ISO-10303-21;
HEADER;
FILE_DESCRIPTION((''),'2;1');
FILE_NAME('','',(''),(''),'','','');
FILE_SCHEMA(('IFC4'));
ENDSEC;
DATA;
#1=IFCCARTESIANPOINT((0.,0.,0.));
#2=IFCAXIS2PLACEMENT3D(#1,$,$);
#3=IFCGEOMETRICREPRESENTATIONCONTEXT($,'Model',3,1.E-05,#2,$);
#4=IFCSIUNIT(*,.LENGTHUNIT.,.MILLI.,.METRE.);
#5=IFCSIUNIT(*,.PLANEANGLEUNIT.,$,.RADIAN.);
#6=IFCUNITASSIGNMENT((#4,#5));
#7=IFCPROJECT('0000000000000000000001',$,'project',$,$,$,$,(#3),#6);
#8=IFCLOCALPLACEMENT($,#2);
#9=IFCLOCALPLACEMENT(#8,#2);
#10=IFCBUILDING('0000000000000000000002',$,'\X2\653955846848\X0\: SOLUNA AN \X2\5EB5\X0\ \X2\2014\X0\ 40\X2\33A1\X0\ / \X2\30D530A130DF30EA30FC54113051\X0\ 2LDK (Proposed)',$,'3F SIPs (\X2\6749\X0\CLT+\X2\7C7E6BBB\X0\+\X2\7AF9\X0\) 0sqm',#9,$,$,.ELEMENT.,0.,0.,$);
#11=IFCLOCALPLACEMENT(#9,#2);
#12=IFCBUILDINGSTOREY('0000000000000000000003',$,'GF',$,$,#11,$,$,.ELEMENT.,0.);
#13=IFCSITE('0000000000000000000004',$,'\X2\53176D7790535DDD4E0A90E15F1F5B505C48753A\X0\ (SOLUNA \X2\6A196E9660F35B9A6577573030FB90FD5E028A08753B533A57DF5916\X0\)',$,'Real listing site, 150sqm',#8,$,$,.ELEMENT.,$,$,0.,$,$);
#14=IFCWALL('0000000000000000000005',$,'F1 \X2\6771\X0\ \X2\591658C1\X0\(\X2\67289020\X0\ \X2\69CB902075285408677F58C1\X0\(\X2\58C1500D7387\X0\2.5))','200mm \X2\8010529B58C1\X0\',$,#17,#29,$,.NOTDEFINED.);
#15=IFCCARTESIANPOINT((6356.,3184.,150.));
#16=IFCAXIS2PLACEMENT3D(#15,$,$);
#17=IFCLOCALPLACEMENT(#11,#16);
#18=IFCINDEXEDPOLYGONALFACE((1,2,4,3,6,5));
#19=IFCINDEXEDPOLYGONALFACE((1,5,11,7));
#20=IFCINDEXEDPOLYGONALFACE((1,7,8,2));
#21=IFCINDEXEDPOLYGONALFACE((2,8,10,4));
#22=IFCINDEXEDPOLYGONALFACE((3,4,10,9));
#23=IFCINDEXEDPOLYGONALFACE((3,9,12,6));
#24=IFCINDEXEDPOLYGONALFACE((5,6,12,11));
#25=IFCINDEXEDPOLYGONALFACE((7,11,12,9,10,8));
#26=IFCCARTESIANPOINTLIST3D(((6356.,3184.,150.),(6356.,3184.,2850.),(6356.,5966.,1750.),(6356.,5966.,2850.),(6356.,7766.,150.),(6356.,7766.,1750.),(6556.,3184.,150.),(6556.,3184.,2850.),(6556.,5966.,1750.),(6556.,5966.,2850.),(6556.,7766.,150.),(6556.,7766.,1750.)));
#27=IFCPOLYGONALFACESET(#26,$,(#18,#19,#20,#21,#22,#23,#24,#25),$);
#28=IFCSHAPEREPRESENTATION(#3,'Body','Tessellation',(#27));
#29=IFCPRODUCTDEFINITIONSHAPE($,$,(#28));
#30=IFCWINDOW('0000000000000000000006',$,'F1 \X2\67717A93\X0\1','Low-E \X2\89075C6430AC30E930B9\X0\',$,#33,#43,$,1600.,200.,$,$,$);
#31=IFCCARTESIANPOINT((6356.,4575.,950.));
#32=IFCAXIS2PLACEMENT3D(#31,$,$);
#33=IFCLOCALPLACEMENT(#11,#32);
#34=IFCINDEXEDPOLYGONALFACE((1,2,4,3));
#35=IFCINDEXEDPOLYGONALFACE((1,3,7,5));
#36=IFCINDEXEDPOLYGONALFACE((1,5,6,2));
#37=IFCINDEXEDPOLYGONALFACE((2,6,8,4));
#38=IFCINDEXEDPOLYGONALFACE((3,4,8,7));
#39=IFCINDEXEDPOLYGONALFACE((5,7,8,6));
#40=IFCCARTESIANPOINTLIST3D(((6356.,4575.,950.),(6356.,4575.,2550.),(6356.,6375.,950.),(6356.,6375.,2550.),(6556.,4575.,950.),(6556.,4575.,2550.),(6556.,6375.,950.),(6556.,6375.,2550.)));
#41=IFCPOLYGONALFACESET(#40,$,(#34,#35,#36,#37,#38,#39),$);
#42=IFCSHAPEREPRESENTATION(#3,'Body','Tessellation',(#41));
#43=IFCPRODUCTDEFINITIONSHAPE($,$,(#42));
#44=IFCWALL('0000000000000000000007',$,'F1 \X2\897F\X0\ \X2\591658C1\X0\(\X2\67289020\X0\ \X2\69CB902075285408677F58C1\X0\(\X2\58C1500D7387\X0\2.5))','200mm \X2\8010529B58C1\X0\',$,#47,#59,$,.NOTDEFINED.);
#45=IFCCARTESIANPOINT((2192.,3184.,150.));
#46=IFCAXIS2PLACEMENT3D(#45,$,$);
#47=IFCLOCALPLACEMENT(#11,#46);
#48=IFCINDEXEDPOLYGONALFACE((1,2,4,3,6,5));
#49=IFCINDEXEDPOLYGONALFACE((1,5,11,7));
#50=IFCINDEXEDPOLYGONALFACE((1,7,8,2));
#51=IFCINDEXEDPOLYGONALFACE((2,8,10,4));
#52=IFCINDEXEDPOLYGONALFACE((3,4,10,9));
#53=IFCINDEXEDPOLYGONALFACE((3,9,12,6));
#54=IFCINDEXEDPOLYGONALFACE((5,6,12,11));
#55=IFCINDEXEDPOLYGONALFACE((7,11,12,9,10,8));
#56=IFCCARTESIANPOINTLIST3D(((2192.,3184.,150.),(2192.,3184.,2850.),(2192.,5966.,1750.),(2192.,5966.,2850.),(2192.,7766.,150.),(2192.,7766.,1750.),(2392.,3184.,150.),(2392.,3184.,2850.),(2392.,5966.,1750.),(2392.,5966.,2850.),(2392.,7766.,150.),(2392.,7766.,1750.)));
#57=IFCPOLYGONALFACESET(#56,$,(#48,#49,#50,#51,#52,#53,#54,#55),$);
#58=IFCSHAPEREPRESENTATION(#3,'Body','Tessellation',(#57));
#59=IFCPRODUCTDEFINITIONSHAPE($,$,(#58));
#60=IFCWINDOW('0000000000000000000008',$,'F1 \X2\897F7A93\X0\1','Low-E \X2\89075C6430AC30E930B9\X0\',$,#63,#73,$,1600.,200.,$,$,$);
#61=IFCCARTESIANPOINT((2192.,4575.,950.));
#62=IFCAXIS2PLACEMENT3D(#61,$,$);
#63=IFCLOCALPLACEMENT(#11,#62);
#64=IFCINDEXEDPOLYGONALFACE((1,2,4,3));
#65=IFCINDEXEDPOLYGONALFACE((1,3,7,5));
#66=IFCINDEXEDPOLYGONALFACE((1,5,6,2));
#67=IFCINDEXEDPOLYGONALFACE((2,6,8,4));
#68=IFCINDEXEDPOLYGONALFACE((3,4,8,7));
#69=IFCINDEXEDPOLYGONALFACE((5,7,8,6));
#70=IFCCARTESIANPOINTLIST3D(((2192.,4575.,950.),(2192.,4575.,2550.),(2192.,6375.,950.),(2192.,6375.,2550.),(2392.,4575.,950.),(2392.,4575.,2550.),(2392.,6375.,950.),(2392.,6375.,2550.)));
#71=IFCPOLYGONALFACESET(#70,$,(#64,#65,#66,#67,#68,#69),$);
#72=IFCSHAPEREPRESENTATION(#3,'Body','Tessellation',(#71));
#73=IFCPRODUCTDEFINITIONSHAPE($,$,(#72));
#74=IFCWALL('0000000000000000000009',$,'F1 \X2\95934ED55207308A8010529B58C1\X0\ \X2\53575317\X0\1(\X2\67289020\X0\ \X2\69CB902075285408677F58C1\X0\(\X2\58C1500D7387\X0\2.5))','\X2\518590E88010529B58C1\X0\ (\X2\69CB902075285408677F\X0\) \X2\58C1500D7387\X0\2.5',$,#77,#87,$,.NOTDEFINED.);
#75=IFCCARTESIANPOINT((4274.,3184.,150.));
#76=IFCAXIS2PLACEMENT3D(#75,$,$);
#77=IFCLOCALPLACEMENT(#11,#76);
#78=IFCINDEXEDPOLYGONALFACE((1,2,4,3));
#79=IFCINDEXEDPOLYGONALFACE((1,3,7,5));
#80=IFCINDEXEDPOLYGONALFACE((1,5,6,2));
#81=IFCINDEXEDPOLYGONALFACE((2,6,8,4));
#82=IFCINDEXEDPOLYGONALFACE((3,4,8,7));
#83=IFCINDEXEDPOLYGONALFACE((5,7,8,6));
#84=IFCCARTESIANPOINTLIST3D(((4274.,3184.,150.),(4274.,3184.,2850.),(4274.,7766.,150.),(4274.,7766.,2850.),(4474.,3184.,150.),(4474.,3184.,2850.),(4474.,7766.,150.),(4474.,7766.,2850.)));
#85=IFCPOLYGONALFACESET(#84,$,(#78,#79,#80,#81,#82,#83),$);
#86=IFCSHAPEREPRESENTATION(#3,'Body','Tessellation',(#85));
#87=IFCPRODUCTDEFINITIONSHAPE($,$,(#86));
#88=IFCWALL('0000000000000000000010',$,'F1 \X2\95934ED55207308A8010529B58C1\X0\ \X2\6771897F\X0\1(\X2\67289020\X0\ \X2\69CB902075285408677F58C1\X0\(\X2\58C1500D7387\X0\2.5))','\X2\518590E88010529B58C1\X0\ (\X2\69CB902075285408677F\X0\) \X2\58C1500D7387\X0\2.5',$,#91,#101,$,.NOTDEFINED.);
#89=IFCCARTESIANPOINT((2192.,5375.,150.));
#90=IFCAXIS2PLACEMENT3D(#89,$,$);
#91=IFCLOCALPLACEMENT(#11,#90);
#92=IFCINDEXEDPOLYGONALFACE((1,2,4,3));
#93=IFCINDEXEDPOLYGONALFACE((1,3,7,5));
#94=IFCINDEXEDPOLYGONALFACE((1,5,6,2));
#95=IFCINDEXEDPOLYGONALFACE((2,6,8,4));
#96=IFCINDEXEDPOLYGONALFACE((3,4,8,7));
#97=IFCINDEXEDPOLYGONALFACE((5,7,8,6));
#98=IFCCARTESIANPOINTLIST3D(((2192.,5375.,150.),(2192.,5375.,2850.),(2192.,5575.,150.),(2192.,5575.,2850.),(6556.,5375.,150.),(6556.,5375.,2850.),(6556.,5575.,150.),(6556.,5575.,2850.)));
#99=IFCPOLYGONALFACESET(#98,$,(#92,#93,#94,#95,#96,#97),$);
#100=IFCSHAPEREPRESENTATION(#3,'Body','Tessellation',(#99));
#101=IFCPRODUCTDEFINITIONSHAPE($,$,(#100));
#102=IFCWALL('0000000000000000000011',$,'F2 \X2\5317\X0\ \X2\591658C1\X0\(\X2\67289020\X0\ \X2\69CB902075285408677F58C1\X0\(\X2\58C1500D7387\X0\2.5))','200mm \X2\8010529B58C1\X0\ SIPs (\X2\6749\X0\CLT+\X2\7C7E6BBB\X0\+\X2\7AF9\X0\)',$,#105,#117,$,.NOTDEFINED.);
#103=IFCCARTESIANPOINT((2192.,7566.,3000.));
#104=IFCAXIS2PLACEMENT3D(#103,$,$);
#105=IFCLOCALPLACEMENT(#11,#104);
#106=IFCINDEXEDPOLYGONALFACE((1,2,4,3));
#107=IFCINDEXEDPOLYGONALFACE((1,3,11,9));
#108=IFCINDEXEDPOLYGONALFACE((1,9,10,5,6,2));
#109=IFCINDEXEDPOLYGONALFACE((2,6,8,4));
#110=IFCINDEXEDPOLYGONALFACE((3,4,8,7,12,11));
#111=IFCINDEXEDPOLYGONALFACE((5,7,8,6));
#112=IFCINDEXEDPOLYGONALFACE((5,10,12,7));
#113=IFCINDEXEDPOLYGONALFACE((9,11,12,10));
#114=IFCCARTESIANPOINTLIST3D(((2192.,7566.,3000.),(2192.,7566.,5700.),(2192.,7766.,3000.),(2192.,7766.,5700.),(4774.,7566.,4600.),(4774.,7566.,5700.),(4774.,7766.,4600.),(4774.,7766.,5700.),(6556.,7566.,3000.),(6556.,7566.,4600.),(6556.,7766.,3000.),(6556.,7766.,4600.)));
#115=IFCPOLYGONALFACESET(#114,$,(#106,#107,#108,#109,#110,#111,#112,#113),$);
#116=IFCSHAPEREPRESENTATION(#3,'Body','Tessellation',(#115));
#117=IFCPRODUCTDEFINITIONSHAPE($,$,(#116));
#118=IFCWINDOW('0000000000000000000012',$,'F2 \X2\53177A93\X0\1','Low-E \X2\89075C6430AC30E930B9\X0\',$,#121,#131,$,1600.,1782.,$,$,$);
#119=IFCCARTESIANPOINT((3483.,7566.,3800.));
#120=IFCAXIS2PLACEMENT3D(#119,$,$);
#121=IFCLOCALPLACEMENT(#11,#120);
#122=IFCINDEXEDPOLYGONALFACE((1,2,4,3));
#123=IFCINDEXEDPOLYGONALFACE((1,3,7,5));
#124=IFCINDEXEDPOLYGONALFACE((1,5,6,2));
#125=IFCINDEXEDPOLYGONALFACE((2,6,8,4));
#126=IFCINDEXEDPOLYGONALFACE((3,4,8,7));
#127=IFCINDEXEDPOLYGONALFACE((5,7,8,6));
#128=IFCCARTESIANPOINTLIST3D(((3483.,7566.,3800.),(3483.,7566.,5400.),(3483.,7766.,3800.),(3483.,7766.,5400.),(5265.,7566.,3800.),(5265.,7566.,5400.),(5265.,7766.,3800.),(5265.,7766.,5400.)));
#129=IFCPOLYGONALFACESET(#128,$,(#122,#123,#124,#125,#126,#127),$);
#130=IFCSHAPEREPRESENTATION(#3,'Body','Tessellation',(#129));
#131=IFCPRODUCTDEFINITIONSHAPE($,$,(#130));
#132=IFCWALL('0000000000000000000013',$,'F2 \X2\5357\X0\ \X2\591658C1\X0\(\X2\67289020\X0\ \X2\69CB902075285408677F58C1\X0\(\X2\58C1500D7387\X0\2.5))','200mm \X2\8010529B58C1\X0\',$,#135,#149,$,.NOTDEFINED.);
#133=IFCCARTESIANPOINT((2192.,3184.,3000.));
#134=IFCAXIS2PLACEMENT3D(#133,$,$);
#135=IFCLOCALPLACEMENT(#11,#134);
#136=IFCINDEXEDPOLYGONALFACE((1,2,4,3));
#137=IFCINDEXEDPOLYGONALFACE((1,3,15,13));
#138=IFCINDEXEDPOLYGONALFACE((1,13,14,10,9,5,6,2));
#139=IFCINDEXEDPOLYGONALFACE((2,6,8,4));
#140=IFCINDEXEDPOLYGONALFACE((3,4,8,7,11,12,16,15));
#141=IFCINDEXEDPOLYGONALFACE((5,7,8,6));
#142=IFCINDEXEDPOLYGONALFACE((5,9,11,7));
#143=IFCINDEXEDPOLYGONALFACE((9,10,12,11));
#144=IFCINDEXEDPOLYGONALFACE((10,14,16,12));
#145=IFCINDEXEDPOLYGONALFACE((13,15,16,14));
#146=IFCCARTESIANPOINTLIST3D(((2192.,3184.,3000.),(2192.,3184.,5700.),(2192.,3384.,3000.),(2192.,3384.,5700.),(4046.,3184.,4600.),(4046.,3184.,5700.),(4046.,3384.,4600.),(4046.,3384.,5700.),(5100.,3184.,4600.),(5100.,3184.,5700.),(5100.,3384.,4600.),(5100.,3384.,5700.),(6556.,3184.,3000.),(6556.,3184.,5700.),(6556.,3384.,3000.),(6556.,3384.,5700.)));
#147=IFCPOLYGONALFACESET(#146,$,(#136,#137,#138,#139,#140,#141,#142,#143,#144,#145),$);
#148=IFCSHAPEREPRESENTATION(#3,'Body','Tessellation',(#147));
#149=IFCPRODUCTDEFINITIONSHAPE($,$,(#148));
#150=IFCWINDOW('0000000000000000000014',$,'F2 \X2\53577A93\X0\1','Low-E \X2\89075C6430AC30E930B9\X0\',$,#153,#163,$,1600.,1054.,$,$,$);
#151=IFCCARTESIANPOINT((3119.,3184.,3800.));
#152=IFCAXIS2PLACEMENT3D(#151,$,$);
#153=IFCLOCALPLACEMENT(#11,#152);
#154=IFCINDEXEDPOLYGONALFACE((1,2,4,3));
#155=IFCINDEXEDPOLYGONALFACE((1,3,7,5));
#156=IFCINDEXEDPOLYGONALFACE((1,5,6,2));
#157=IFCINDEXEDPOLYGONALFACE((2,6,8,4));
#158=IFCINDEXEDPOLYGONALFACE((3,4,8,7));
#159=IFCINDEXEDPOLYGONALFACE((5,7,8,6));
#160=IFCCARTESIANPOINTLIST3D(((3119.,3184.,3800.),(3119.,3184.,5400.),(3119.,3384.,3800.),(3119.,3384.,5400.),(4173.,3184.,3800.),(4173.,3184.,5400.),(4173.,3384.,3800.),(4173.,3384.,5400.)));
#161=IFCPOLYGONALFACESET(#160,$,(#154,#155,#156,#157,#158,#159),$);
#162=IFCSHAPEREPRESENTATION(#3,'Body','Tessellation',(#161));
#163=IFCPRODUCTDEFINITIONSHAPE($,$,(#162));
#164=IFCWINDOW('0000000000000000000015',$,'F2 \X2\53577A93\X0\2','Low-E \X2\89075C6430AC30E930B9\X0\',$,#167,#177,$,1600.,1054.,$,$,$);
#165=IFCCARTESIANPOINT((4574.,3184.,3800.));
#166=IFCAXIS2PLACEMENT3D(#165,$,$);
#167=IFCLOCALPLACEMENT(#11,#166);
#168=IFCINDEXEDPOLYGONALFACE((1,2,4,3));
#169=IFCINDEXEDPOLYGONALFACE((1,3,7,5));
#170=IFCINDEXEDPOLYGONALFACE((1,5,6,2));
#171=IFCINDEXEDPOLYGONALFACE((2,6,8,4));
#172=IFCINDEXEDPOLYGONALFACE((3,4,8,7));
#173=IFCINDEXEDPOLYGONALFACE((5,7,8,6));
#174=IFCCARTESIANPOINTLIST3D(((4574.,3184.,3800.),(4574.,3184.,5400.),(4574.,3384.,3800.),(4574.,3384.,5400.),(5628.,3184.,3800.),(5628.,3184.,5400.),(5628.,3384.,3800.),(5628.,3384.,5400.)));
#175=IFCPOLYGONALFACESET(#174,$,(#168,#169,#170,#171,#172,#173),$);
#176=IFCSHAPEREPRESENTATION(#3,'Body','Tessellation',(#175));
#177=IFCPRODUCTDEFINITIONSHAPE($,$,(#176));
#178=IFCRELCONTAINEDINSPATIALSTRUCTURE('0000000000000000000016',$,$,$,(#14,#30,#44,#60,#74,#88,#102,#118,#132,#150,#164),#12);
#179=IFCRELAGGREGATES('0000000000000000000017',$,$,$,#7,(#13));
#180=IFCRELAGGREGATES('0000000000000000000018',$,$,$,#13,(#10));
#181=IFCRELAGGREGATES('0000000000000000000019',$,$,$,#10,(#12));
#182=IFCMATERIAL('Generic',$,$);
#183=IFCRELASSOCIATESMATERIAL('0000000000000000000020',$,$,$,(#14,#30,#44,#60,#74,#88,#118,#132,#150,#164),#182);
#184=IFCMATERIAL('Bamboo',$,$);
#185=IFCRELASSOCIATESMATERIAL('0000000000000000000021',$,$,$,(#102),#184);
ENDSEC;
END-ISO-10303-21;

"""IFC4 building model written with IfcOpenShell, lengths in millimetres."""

from ifc_helpers import new_model, si_unit, frame, frame_2d, origin, place, context, project, spatial, rectangle, extrude, material, element, fill, save


model = new_model("IFC4")

# Units and contexts
model_context = context("Model", 3, precision=1e-05, world=origin())
ifc_project = project(units=[si_unit("LENGTHUNIT", "METRE", prefix="MILLI"), si_unit("PLANEANGLEUNIT", "RADIAN")], contexts=[model_context])

# Site, building, storey
site_placement = place(None, origin())
site = spatial("IfcSite", under=ifc_project, at=site_placement, Name="北海道川上郡弟子屈町 (SOLUNA 標準想定敷地・都市計画区域外)", ObjectType="Real listing site, 150sqm", CompositionType="ELEMENT", RefElevation=0.0)
building_placement = place(site_placement, origin())
building = spatial("IfcBuilding", under=site, at=building_placement, Name="改善案: SOLUNA AN 庵 — 40㎡ / ファミリー向け 2LDK (Proposed)", ObjectType="3F SIPs (杉CLT+籾殻+竹) 0sqm", CompositionType="ELEMENT", ElevationOfRefHeight=0.0, ElevationOfTerrain=0.0)
storey_placement = place(building_placement, origin())
storey = spatial("IfcBuildingStorey", under=building, at=storey_placement, Name="GF", CompositionType="ELEMENT", Elevation=0.0)

# Shared definitions
ifc_material_1 = material(Name="Generic")

# Shared definitions
ifc_material_2 = material(Name="Bamboo")

# Walls, openings, windows
wall_1_placement = place(storey_placement, frame((6356.0, 3184.0, 150.0)))
wall_1 = element("IfcWall", 1, at=wall_1_placement, inside=storey, material=ifc_material_1, Name="F1 東 外壁(木造 構造用合板壁(壁倍率2.5))", Description="200mm 耐力壁", PredefinedType="NOTDEFINED", context=model_context, shape_type="SweptSolid", body=[
    extrude(rectangle(XDim=200.0, YDim=4582.0, at=frame_2d((100.0, 2291.0))), frame((6356.0, 3184.0, 150.0)), (0.0, 0.0, 1.0), 2700.0),
])
opening_1_placement = place(storey_placement, frame((6356.0, 4575.0, 950.0)))
opening_1 = element("IfcOpeningElement", 2, at=opening_1_placement, cuts=wall_1, PredefinedType="NOTDEFINED", context=model_context, shape_type="SweptSolid", body=[
    extrude(rectangle(XDim=200.0, YDim=1800.0, at=frame_2d((100.0, 900.0))), frame((6356.0, 4575.0, 950.0)), (0.0, 0.0, 1.0), 1600.0),
])
window_1_placement = place(storey_placement, frame((6356.0, 4575.0, 950.0)))
window_1 = element("IfcWindow", 3, at=window_1_placement, inside=storey, material=ifc_material_1, Name="F1 東窓1", Description="Low-E 複層ガラス", OverallHeight=1600.0, OverallWidth=200.0, context=model_context, shape_type="SweptSolid", body=[
    extrude(rectangle(XDim=200.0, YDim=1800.0, at=frame_2d((100.0, 900.0))), frame((6356.0, 4575.0, 950.0)), (0.0, 0.0, 1.0), 1600.0),
])
fill(opening_1, window_1)
wall_2_placement = place(storey_placement, frame((2192.0, 3184.0, 150.0)))
wall_2 = element("IfcWall", 4, at=wall_2_placement, inside=storey, material=ifc_material_1, Name="F1 西 外壁(木造 構造用合板壁(壁倍率2.5))", Description="200mm 耐力壁", PredefinedType="NOTDEFINED", context=model_context, shape_type="SweptSolid", body=[
    extrude(rectangle(XDim=200.0, YDim=4582.0, at=frame_2d((100.0, 2291.0))), frame((2192.0, 3184.0, 150.0)), (0.0, 0.0, 1.0), 2700.0),
])
opening_2_placement = place(storey_placement, frame((2192.0, 4575.0, 950.0)))
opening_2 = element("IfcOpeningElement", 5, at=opening_2_placement, cuts=wall_2, PredefinedType="NOTDEFINED", context=model_context, shape_type="SweptSolid", body=[
    extrude(rectangle(XDim=200.0, YDim=1800.0, at=frame_2d((100.0, 900.0))), frame((2192.0, 4575.0, 950.0)), (0.0, 0.0, 1.0), 1600.0),
])
window_2_placement = place(storey_placement, frame((2192.0, 4575.0, 950.0)))
window_2 = element("IfcWindow", 6, at=window_2_placement, inside=storey, material=ifc_material_1, Name="F1 西窓1", Description="Low-E 複層ガラス", OverallHeight=1600.0, OverallWidth=200.0, context=model_context, shape_type="SweptSolid", body=[
    extrude(rectangle(XDim=200.0, YDim=1800.0, at=frame_2d((100.0, 900.0))), frame((2192.0, 4575.0, 950.0)), (0.0, 0.0, 1.0), 1600.0),
])
fill(opening_2, window_2)

# Walls
wall_3_placement = place(storey_placement, frame((4274.0, 3184.0, 150.0)))
element("IfcWall", 7, at=wall_3_placement, inside=storey, material=ifc_material_1, Name="F1 間仕切り耐力壁 南北1(木造 構造用合板壁(壁倍率2.5))", Description="内部耐力壁 (構造用合板) 壁倍率2.5", PredefinedType="NOTDEFINED", context=model_context, shape_type="SweptSolid", body=[
    extrude(rectangle(XDim=200.0, YDim=4582.0, at=frame_2d((100.0, 2291.0))), frame((4274.0, 3184.0, 150.0)), (0.0, 0.0, 1.0), 2700.0),
])
wall_4_placement = place(storey_placement, frame((2192.0, 5375.0, 150.0)))
element("IfcWall", 8, at=wall_4_placement, inside=storey, material=ifc_material_1, Name="F1 間仕切り耐力壁 東西1(木造 構造用合板壁(壁倍率2.5))", Description="内部耐力壁 (構造用合板) 壁倍率2.5", PredefinedType="NOTDEFINED", context=model_context, shape_type="SweptSolid", body=[
    extrude(rectangle(XDim=4364.0, YDim=200.0, at=frame_2d((2182.0, 100.0))), frame((2192.0, 5375.0, 150.0)), (0.0, 0.0, 1.0), 2700.0),
])

# Wall, opening, window
wall_5_placement = place(storey_placement, frame((2192.0, 7566.0, 3000.0)))
wall_5 = element("IfcWall", 9, at=wall_5_placement, inside=storey, material=ifc_material_2, Name="F2 北 外壁(木造 構造用合板壁(壁倍率2.5))", Description="200mm 耐力壁 SIPs (杉CLT+籾殻+竹)", PredefinedType="NOTDEFINED", context=model_context, shape_type="SweptSolid", body=[
    extrude(rectangle(XDim=4364.0, YDim=200.0, at=frame_2d((2182.0, 100.0))), frame((2192.0, 7566.0, 3000.0)), (0.0, 0.0, 1.0), 2700.0),
])
opening_3_placement = place(storey_placement, frame((3483.0, 7566.0, 3800.0)))
opening_3 = element("IfcOpeningElement", 10, at=opening_3_placement, cuts=wall_5, PredefinedType="NOTDEFINED", context=model_context, shape_type="SweptSolid", body=[
    extrude(rectangle(XDim=1782.0, YDim=200.0, at=frame_2d((891.0, 100.0))), frame((3483.0, 7566.0, 3800.0)), (0.0, 0.0, 1.0), 1600.0),
])
window_3_placement = place(storey_placement, frame((3483.0, 7566.0, 3800.0)))
window_3 = element("IfcWindow", 11, at=window_3_placement, inside=storey, material=ifc_material_1, Name="F2 北窓1", Description="Low-E 複層ガラス", OverallHeight=1600.0, OverallWidth=1782.0, context=model_context, shape_type="SweptSolid", body=[
    extrude(rectangle(XDim=1782.0, YDim=200.0, at=frame_2d((891.0, 100.0))), frame((3483.0, 7566.0, 3800.0)), (0.0, 0.0, 1.0), 1600.0),
])
fill(opening_3, window_3)

# Wall, openings, windows
wall_6_placement = place(storey_placement, frame((2192.0, 3184.0, 3000.0)))
wall_6 = element("IfcWall", 12, at=wall_6_placement, inside=storey, material=ifc_material_1, Name="F2 南 外壁(木造 構造用合板壁(壁倍率2.5))", Description="200mm 耐力壁", PredefinedType="NOTDEFINED", context=model_context, shape_type="SweptSolid", body=[
    extrude(rectangle(XDim=4364.0, YDim=200.0, at=frame_2d((2182.0, 100.0))), frame((2192.0, 3184.0, 3000.0)), (0.0, 0.0, 1.0), 2700.0),
])
opening_4_placement = place(storey_placement, frame((3119.0, 3184.0, 3800.0)))
opening_4 = element("IfcOpeningElement", 13, at=opening_4_placement, cuts=wall_6, PredefinedType="NOTDEFINED", context=model_context, shape_type="SweptSolid", body=[
    extrude(rectangle(XDim=1054.0, YDim=200.0, at=frame_2d((527.0, 100.0))), frame((3119.0, 3184.0, 3800.0)), (0.0, 0.0, 1.0), 1600.0),
])
opening_5_placement = place(storey_placement, frame((4574.0, 3184.0, 3800.0)))
opening_5 = element("IfcOpeningElement", 14, at=opening_5_placement, cuts=wall_6, PredefinedType="NOTDEFINED", context=model_context, shape_type="SweptSolid", body=[
    extrude(rectangle(XDim=1054.0, YDim=200.0, at=frame_2d((527.0, 100.0))), frame((4574.0, 3184.0, 3800.0)), (0.0, 0.0, 1.0), 1600.0),
])
window_4_placement = place(storey_placement, frame((3119.0, 3184.0, 3800.0)))
window_4 = element("IfcWindow", 15, at=window_4_placement, inside=storey, material=ifc_material_1, Name="F2 南窓1", Description="Low-E 複層ガラス", OverallHeight=1600.0, OverallWidth=1054.0, context=model_context, shape_type="SweptSolid", body=[
    extrude(rectangle(XDim=1054.0, YDim=200.0, at=frame_2d((527.0, 100.0))), frame((3119.0, 3184.0, 3800.0)), (0.0, 0.0, 1.0), 1600.0),
])
fill(opening_4, window_4)
window_5_placement = place(storey_placement, frame((4574.0, 3184.0, 3800.0)))
window_5 = element("IfcWindow", 16, at=window_5_placement, inside=storey, material=ifc_material_1, Name="F2 南窓2", Description="Low-E 複層ガラス", OverallHeight=1600.0, OverallWidth=1054.0, context=model_context, shape_type="SweptSolid", body=[
    extrude(rectangle(XDim=1054.0, YDim=200.0, at=frame_2d((527.0, 100.0))), frame((4574.0, 3184.0, 3800.0)), (0.0, 0.0, 1.0), 1600.0),
])
fill(opening_5, window_5)

save(model, "model.ifc")
